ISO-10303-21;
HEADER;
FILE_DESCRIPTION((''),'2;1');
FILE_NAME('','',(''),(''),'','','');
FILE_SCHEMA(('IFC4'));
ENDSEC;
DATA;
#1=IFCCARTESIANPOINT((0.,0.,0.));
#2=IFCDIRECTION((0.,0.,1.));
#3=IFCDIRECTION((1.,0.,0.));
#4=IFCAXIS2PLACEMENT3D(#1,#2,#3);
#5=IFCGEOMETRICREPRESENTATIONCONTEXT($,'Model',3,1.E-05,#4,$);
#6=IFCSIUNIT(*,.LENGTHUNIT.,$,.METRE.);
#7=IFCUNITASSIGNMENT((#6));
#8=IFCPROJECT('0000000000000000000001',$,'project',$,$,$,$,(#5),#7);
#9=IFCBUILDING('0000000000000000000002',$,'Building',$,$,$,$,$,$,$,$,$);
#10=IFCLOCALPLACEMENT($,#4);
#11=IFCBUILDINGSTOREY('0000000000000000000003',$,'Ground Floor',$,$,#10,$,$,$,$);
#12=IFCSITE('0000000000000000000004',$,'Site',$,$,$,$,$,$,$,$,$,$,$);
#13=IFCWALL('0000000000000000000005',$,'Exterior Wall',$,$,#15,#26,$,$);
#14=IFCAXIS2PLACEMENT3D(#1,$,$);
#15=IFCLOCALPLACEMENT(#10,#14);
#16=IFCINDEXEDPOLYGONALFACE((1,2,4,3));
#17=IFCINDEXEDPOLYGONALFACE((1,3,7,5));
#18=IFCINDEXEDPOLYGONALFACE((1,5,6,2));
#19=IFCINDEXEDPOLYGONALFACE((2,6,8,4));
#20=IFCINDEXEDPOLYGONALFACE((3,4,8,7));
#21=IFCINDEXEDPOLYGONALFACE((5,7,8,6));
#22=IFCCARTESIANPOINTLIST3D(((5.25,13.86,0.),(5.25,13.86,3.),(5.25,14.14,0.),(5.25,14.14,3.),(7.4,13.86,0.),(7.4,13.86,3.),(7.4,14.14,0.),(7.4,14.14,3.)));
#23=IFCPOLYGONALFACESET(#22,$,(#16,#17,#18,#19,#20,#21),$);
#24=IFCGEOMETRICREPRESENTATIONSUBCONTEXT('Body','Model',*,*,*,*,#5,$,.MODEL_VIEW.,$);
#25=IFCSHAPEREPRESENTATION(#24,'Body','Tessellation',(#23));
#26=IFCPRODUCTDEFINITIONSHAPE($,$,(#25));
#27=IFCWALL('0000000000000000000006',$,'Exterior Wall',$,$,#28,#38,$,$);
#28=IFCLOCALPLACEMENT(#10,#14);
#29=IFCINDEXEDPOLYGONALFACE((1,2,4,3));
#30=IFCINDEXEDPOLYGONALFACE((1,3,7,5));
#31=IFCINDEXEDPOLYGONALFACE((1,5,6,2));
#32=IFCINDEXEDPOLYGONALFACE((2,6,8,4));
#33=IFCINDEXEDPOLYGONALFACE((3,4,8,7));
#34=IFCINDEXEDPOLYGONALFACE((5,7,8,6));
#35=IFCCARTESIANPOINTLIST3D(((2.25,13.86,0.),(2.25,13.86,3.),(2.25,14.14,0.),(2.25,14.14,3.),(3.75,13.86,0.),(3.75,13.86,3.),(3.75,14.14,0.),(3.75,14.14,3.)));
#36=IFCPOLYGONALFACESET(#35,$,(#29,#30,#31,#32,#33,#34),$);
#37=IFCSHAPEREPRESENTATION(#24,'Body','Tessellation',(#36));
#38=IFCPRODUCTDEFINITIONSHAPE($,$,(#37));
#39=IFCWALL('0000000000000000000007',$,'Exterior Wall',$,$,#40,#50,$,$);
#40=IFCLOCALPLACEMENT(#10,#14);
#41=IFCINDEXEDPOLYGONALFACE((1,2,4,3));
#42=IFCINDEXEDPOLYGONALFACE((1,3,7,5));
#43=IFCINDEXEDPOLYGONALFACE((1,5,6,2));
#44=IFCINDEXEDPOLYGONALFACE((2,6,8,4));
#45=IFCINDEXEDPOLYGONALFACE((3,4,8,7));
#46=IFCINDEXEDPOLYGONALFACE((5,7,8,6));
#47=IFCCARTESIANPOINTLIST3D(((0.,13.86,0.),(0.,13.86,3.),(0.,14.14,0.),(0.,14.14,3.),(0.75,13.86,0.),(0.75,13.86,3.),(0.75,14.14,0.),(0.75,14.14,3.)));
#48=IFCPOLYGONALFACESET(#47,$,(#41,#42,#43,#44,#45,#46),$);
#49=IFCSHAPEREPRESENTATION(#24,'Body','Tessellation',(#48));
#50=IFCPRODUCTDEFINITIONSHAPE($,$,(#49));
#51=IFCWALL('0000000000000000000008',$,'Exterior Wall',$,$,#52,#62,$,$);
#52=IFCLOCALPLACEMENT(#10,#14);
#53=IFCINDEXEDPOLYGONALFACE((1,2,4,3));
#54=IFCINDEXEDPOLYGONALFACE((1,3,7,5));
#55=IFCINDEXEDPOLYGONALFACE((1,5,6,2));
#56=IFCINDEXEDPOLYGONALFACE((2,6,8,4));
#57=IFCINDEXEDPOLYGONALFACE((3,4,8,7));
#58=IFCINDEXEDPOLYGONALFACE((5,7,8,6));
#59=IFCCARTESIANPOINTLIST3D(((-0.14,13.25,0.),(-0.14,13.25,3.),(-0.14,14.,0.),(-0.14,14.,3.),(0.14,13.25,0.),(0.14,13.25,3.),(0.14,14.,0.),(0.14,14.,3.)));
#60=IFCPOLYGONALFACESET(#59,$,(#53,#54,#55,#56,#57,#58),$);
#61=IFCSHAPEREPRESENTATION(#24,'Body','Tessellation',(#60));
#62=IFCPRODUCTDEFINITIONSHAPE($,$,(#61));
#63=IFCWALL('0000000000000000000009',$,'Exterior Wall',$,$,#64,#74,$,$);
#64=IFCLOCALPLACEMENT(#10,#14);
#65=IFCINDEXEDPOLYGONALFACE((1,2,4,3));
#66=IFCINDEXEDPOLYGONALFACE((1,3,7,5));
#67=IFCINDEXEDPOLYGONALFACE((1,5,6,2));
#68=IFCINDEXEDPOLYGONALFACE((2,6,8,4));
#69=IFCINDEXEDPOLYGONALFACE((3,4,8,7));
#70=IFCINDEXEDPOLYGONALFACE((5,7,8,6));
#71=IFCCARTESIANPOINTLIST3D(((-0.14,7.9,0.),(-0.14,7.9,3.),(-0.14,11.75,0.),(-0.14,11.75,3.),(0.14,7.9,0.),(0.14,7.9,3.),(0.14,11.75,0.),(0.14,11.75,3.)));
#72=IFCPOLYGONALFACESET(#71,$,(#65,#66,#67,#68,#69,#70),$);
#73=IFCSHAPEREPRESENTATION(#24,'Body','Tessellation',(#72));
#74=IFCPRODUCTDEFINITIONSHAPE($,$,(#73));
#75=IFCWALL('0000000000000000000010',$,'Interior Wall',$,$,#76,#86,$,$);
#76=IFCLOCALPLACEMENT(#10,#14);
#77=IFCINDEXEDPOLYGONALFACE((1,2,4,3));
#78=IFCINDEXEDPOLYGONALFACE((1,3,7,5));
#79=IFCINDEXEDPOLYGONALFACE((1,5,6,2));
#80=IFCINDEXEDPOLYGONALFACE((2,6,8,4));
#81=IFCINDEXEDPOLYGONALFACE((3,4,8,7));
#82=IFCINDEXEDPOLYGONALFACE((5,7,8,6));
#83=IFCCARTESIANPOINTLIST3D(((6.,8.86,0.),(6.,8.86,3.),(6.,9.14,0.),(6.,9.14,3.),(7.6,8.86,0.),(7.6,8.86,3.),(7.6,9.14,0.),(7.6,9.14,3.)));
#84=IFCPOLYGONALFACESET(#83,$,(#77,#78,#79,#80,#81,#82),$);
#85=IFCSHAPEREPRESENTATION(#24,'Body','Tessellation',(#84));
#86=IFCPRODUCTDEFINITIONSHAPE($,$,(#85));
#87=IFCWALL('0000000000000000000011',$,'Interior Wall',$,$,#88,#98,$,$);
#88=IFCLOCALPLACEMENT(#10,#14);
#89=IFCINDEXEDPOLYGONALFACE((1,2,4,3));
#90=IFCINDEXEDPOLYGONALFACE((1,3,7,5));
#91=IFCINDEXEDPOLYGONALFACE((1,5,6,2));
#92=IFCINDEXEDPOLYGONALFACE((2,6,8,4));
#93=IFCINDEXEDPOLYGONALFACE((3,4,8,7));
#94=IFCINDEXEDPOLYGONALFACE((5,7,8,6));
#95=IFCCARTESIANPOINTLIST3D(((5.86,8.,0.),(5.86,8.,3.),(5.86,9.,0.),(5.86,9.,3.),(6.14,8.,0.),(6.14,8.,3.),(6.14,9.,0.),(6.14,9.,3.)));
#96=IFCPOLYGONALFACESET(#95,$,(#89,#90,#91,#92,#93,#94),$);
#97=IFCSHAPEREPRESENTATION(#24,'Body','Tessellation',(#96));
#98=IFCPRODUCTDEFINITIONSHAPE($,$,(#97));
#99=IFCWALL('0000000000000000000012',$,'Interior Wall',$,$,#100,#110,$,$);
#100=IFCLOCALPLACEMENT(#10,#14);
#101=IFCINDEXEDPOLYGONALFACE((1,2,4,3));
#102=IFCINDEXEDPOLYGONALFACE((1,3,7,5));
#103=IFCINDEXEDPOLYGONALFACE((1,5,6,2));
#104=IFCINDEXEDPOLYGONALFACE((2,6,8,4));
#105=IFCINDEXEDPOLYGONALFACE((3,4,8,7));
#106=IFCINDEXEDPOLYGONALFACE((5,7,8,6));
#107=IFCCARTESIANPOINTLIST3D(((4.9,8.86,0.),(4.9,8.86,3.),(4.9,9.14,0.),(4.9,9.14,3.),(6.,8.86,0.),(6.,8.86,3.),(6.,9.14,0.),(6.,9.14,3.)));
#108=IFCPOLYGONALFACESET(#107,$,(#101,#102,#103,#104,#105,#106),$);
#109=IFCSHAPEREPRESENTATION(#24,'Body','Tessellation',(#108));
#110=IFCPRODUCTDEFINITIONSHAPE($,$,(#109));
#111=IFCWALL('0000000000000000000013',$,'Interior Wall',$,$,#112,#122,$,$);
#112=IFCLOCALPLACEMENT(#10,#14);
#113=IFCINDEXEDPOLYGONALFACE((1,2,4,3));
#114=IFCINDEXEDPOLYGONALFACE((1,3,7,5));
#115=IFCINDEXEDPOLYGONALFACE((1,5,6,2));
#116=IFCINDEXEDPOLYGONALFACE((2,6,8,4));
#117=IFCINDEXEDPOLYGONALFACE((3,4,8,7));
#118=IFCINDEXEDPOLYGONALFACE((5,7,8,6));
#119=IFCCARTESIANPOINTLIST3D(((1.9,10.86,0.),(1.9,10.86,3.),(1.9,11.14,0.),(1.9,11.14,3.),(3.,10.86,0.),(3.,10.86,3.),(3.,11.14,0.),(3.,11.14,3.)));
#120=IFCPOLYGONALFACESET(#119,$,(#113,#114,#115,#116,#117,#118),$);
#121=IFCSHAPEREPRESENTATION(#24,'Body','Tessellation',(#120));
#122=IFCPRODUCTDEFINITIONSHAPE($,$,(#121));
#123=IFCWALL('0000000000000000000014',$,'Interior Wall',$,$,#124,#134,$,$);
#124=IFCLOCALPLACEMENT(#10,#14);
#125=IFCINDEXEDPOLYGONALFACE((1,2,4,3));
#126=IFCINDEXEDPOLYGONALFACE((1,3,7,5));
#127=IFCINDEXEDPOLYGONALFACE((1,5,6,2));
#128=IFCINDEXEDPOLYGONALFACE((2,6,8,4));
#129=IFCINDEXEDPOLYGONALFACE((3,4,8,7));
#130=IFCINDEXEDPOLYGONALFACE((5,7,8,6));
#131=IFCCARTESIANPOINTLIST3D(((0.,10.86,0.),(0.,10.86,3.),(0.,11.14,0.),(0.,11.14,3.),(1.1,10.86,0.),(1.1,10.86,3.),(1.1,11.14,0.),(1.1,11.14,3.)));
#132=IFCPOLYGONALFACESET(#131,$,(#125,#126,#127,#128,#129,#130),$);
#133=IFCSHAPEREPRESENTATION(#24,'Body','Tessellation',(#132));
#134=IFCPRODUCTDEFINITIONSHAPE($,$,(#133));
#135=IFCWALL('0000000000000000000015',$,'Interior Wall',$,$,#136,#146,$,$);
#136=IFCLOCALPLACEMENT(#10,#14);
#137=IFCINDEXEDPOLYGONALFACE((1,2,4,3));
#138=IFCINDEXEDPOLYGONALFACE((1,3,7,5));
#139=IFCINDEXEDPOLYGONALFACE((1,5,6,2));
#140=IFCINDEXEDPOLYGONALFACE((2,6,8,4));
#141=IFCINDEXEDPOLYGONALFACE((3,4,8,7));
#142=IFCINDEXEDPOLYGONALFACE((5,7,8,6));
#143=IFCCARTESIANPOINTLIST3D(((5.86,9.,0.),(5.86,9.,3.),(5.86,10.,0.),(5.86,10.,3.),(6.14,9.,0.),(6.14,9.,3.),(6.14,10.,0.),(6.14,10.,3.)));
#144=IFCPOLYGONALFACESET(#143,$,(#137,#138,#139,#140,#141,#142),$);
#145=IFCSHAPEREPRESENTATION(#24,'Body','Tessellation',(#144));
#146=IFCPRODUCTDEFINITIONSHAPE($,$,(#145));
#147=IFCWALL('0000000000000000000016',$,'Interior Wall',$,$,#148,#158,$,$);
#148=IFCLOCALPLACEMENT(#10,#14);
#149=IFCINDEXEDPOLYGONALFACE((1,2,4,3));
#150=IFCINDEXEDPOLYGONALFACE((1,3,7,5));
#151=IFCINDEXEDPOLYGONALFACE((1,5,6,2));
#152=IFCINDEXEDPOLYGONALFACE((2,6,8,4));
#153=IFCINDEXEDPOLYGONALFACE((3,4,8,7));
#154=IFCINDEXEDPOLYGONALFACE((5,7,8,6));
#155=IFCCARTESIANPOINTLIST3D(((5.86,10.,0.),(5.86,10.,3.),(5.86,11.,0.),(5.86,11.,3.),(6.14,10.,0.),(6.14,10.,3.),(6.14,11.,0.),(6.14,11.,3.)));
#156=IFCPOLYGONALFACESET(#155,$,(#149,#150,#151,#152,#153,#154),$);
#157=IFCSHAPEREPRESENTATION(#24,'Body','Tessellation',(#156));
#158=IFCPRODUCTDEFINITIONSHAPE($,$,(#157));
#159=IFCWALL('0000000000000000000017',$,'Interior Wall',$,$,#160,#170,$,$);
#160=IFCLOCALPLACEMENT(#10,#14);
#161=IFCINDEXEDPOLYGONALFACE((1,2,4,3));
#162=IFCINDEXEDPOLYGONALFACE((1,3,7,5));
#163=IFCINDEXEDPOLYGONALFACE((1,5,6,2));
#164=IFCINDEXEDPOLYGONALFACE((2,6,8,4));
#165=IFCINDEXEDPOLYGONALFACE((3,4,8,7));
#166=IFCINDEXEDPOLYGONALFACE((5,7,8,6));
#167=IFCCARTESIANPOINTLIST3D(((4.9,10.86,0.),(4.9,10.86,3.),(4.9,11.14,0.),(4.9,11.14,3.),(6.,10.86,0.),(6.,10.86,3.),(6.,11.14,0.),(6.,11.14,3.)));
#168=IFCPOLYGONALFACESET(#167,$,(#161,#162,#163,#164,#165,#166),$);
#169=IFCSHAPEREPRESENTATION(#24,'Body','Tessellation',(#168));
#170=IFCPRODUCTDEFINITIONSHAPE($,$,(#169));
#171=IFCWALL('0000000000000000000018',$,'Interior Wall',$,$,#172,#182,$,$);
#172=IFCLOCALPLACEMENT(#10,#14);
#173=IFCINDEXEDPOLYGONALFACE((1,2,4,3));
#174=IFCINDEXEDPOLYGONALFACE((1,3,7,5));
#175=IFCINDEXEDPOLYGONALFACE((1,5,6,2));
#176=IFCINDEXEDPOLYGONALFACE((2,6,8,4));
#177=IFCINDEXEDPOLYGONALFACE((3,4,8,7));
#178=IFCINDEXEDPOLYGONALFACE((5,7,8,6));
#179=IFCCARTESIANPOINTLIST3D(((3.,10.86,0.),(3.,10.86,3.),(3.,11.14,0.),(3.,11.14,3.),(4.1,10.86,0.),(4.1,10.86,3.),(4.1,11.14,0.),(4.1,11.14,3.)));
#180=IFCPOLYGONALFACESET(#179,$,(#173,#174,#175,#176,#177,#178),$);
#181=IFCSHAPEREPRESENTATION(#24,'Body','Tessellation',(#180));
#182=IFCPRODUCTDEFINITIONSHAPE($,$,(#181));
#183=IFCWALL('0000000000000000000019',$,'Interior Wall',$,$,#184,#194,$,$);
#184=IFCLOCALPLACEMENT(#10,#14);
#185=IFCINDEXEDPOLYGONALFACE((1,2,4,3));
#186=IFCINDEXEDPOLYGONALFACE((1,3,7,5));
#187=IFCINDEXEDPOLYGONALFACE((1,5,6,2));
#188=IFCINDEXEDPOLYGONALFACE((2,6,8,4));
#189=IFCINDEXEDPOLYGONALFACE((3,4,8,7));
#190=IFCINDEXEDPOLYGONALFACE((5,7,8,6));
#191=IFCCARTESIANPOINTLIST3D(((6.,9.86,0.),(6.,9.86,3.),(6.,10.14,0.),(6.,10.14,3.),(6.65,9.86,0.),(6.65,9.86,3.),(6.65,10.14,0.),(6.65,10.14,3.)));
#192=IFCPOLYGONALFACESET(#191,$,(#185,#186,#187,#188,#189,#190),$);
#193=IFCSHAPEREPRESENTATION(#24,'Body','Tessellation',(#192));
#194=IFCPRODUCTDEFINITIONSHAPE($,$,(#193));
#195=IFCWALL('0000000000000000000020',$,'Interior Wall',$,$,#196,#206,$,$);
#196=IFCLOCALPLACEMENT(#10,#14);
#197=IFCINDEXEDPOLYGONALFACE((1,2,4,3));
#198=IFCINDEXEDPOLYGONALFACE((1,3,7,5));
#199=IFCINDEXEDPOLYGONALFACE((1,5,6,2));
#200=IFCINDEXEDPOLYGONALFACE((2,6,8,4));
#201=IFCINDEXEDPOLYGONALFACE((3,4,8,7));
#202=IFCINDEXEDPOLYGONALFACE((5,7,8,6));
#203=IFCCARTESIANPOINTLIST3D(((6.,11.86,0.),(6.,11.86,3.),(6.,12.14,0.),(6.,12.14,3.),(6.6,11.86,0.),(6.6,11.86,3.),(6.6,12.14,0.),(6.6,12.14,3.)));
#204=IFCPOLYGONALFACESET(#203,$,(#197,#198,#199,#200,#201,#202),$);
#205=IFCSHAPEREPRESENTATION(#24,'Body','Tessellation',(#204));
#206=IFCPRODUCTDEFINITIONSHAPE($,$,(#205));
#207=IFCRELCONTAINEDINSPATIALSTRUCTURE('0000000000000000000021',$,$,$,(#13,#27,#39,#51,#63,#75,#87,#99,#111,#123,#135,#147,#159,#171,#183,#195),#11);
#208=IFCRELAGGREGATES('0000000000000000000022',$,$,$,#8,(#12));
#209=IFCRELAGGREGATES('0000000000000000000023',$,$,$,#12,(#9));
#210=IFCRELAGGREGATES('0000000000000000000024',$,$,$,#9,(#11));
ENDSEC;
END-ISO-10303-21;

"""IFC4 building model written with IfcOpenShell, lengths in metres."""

from ifc_helpers import new_model, si_unit, frame, origin_with_axes, place, context, subcontext, project, spatial, indexed_curve, outline, extrude, element, save


model = new_model("IFC4")

# Units and contexts
model_context = context("Model", 3, precision=1e-05, world=origin_with_axes())
body_context = subcontext(model_context, "Body", "Model", "MODEL_VIEW")
ifc_project = project(units=[si_unit("LENGTHUNIT", "METRE")], contexts=[model_context])

# Site, building, storey
site = spatial("IfcSite", under=ifc_project, Name="Site")
building = spatial("IfcBuilding", under=site, Name="Building")
storey_placement = place(None, origin_with_axes())
storey = spatial("IfcBuildingStorey", under=building, at=storey_placement, Name="Ground Floor")

# Walls
wall_1_placement = place(storey_placement, frame((7.4, 14.0, 0.0), z_axis=(0.0, 0.0, 1.0), x_axis=(-1.0, 0.0, 0.0)))
element("IfcWall", 1, at=wall_1_placement, inside=storey, Name="Exterior Wall", context=body_context, shape_type="SweptSolid", body=[
    extrude(outline(indexed_curve([(0.0, 0.0), (0.0, 0.28), (2.15, 0.28), (2.15, 0.0), (0.0, 0.0)], self_intersect=False)), frame((0.0, -0.14, 0.0), z_axis=(0.0, 0.0, 1.0), x_axis=(1.0, 0.0, 0.0)), (0.0, 0.0, 1.0), 3.0),
])
wall_2_placement = place(storey_placement, frame((3.75, 14.0, 0.0), z_axis=(0.0, 0.0, 1.0), x_axis=(-1.0, 0.0, 0.0)))
element("IfcWall", 2, at=wall_2_placement, inside=storey, Name="Exterior Wall", context=body_context, shape_type="SweptSolid", body=[
    extrude(outline(indexed_curve([(0.0, 0.0), (0.0, 0.28), (1.5, 0.28), (1.5, 0.0), (0.0, 0.0)], self_intersect=False)), frame((0.0, -0.14, 0.0), z_axis=(0.0, 0.0, 1.0), x_axis=(1.0, 0.0, 0.0)), (0.0, 0.0, 1.0), 3.0),
])
for number, where, z_axis, x_axis, name in (
    (3, (0.75, 14.0, 0.0), (0.0, 0.0, 1.0), (-1.0, 0.0, 0.0), "Exterior Wall"),
    (4, (0.0, 14.0, 0.0), (0.0, 0.0, 1.0), (0.0, -1.0, 0.0), "Exterior Wall"),
):
    element("IfcWall", number, at=place(storey_placement, frame(where, z_axis=z_axis, x_axis=x_axis)), inside=storey, Name=name, context=body_context, shape_type="SweptSolid", body=[
        extrude(outline(indexed_curve([(0.0, 0.0), (0.0, 0.28), (0.75, 0.28), (0.75, 0.0), (0.0, 0.0)], self_intersect=False)), frame((0.0, -0.14, 0.0), z_axis=(0.0, 0.0, 1.0), x_axis=(1.0, 0.0, 0.0)), (0.0, 0.0, 1.0), 3.0),
    ])
wall_3_placement = place(storey_placement, frame((0.0, 11.75, 0.0), z_axis=(0.0, 0.0, 1.0), x_axis=(0.0, -1.0, 0.0)))
element("IfcWall", 5, at=wall_3_placement, inside=storey, Name="Exterior Wall", context=body_context, shape_type="SweptSolid", body=[
    extrude(outline(indexed_curve([(0.0, 0.0), (0.0, 0.28), (3.85, 0.28), (3.85, 0.0), (0.0, 0.0)], self_intersect=False)), frame((0.0, -0.14, 0.0), z_axis=(0.0, 0.0, 1.0), x_axis=(1.0, 0.0, 0.0)), (0.0, 0.0, 1.0), 3.0),
])
wall_4_placement = place(storey_placement, frame((7.6, 9.0, 0.0), z_axis=(0.0, 0.0, 1.0), x_axis=(-1.0, 0.0, 0.0)))
element("IfcWall", 6, at=wall_4_placement, inside=storey, Name="Interior Wall", context=body_context, shape_type="SweptSolid", body=[
    extrude(outline(indexed_curve([(0.0, 0.0), (0.0, 0.28), (1.6, 0.28), (1.6, 0.0), (0.0, 0.0)], self_intersect=False)), frame((0.0, -0.14, 0.0), z_axis=(0.0, 0.0, 1.0), x_axis=(1.0, 0.0, 0.0)), (0.0, 0.0, 1.0), 3.0),
])
wall_5_placement = place(storey_placement, frame((6.0, 9.0, 0.0), z_axis=(0.0, 0.0, 1.0), x_axis=(0.0, -1.0, 0.0)))
element("IfcWall", 7, at=wall_5_placement, inside=storey, Name="Interior Wall", context=body_context, shape_type="SweptSolid", body=[
    extrude(outline(indexed_curve([(0.0, 0.0), (0.0, 0.28), (1.0, 0.28), (1.0, 0.0), (0.0, 0.0)], self_intersect=False)), frame((0.0, -0.14, 0.0), z_axis=(0.0, 0.0, 1.0), x_axis=(1.0, 0.0, 0.0)), (0.0, 0.0, 1.0), 3.0),
])
wall_6_placement = place(storey_placement, frame((6.0, 9.0, 0.0), z_axis=(0.0, 0.0, 1.0), x_axis=(-1.0, 0.0, 0.0)))
element("IfcWall", 8, at=wall_6_placement, inside=storey, Name="Interior Wall", context=body_context, shape_type="SweptSolid", body=[
    extrude(outline(indexed_curve([(0.0, 0.0), (0.0, 0.28), (1.1, 0.28), (1.1, 0.0), (0.0, 0.0)], self_intersect=False)), frame((0.0, -0.14, 0.0), z_axis=(0.0, 0.0, 1.0), x_axis=(1.0, 0.0, 0.0)), (0.0, 0.0, 1.0), 3.0),
])
for number, where, z_axis, x_axis, name in (
    (9, (3.0, 11.0, 0.0), (0.0, 0.0, 1.0), (-1.0, 0.0, 0.0), "Interior Wall"),
    (10, (1.1, 11.0, 0.0), (0.0, 0.0, 1.0), (-1.0, 0.0, 0.0), "Interior Wall"),
):
    element("IfcWall", number, at=place(storey_placement, frame(where, z_axis=z_axis, x_axis=x_axis)), inside=storey, Name=name, context=body_context, shape_type="SweptSolid", body=[
        extrude(outline(indexed_curve([(0.0, 0.0), (0.0, 0.28), (1.1, 0.28), (1.1, 0.0), (0.0, 0.0)], self_intersect=False)), frame((0.0, -0.14, 0.0), z_axis=(0.0, 0.0, 1.0), x_axis=(1.0, 0.0, 0.0)), (0.0, 0.0, 1.0), 3.0),
    ])
for number, where, z_axis, x_axis, name in (
    (11, (6.0, 9.0, 0.0), (0.0, 0.0, 1.0), (0.0, 1.0, 0.0), "Interior Wall"),
    (12, (6.0, 10.0, 0.0), (0.0, 0.0, 1.0), (0.0, 1.0, 0.0), "Interior Wall"),
):
    element("IfcWall", number, at=place(storey_placement, frame(where, z_axis=z_axis, x_axis=x_axis)), inside=storey, Name=name, context=body_context, shape_type="SweptSolid", body=[
        extrude(outline(indexed_curve([(0.0, 0.0), (0.0, 0.28), (1.0, 0.28), (1.0, 0.0), (0.0, 0.0)], self_intersect=False)), frame((0.0, -0.14, 0.0), z_axis=(0.0, 0.0, 1.0), x_axis=(1.0, 0.0, 0.0)), (0.0, 0.0, 1.0), 3.0),
    ])
for number, where, z_axis, x_axis, name in (
    (13, (6.0, 11.0, 0.0), (0.0, 0.0, 1.0), (-1.0, 0.0, 0.0), "Interior Wall"),
    (14, (4.1, 11.0, 0.0), (0.0, 0.0, 1.0), (-1.0, 0.0, 0.0), "Interior Wall"),
):
    element("IfcWall", number, at=place(storey_placement, frame(where, z_axis=z_axis, x_axis=x_axis)), inside=storey, Name=name, context=body_context, shape_type="SweptSolid", body=[
        extrude(outline(indexed_curve([(0.0, 0.0), (0.0, 0.28), (1.1, 0.28), (1.1, 0.0), (0.0, 0.0)], self_intersect=False)), frame((0.0, -0.14, 0.0), z_axis=(0.0, 0.0, 1.0), x_axis=(1.0, 0.0, 0.0)), (0.0, 0.0, 1.0), 3.0),
    ])
wall_7_placement = place(storey_placement, frame((6.65, 10.0, 0.0), z_axis=(0.0, 0.0, 1.0), x_axis=(-1.0, 0.0, 0.0)))
element("IfcWall", 15, at=wall_7_placement, inside=storey, Name="Interior Wall", context=body_context, shape_type="SweptSolid", body=[
    extrude(outline(indexed_curve([(0.0, 0.0), (0.0, 0.28), (0.65, 0.28), (0.65, 0.0), (0.0, 0.0)], self_intersect=False)), frame((0.0, -0.14, 0.0), z_axis=(0.0, 0.0, 1.0), x_axis=(1.0, 0.0, 0.0)), (0.0, 0.0, 1.0), 3.0),
])
wall_8_placement = place(storey_placement, frame((6.6, 12.0, 0.0), z_axis=(0.0, 0.0, 1.0), x_axis=(-1.0, 0.0, 0.0)))
element("IfcWall", 16, at=wall_8_placement, inside=storey, Name="Interior Wall", context=body_context, shape_type="SweptSolid", body=[
    extrude(outline(indexed_curve([(0.0, 0.0), (0.0, 0.28), (0.6, 0.28), (0.6, 0.0), (0.0, 0.0)], self_intersect=False)), frame((0.0, -0.14, 0.0), z_axis=(0.0, 0.0, 1.0), x_axis=(1.0, 0.0, 0.0)), (0.0, 0.0, 1.0), 3.0),
])

save(model, "model.ifc")
